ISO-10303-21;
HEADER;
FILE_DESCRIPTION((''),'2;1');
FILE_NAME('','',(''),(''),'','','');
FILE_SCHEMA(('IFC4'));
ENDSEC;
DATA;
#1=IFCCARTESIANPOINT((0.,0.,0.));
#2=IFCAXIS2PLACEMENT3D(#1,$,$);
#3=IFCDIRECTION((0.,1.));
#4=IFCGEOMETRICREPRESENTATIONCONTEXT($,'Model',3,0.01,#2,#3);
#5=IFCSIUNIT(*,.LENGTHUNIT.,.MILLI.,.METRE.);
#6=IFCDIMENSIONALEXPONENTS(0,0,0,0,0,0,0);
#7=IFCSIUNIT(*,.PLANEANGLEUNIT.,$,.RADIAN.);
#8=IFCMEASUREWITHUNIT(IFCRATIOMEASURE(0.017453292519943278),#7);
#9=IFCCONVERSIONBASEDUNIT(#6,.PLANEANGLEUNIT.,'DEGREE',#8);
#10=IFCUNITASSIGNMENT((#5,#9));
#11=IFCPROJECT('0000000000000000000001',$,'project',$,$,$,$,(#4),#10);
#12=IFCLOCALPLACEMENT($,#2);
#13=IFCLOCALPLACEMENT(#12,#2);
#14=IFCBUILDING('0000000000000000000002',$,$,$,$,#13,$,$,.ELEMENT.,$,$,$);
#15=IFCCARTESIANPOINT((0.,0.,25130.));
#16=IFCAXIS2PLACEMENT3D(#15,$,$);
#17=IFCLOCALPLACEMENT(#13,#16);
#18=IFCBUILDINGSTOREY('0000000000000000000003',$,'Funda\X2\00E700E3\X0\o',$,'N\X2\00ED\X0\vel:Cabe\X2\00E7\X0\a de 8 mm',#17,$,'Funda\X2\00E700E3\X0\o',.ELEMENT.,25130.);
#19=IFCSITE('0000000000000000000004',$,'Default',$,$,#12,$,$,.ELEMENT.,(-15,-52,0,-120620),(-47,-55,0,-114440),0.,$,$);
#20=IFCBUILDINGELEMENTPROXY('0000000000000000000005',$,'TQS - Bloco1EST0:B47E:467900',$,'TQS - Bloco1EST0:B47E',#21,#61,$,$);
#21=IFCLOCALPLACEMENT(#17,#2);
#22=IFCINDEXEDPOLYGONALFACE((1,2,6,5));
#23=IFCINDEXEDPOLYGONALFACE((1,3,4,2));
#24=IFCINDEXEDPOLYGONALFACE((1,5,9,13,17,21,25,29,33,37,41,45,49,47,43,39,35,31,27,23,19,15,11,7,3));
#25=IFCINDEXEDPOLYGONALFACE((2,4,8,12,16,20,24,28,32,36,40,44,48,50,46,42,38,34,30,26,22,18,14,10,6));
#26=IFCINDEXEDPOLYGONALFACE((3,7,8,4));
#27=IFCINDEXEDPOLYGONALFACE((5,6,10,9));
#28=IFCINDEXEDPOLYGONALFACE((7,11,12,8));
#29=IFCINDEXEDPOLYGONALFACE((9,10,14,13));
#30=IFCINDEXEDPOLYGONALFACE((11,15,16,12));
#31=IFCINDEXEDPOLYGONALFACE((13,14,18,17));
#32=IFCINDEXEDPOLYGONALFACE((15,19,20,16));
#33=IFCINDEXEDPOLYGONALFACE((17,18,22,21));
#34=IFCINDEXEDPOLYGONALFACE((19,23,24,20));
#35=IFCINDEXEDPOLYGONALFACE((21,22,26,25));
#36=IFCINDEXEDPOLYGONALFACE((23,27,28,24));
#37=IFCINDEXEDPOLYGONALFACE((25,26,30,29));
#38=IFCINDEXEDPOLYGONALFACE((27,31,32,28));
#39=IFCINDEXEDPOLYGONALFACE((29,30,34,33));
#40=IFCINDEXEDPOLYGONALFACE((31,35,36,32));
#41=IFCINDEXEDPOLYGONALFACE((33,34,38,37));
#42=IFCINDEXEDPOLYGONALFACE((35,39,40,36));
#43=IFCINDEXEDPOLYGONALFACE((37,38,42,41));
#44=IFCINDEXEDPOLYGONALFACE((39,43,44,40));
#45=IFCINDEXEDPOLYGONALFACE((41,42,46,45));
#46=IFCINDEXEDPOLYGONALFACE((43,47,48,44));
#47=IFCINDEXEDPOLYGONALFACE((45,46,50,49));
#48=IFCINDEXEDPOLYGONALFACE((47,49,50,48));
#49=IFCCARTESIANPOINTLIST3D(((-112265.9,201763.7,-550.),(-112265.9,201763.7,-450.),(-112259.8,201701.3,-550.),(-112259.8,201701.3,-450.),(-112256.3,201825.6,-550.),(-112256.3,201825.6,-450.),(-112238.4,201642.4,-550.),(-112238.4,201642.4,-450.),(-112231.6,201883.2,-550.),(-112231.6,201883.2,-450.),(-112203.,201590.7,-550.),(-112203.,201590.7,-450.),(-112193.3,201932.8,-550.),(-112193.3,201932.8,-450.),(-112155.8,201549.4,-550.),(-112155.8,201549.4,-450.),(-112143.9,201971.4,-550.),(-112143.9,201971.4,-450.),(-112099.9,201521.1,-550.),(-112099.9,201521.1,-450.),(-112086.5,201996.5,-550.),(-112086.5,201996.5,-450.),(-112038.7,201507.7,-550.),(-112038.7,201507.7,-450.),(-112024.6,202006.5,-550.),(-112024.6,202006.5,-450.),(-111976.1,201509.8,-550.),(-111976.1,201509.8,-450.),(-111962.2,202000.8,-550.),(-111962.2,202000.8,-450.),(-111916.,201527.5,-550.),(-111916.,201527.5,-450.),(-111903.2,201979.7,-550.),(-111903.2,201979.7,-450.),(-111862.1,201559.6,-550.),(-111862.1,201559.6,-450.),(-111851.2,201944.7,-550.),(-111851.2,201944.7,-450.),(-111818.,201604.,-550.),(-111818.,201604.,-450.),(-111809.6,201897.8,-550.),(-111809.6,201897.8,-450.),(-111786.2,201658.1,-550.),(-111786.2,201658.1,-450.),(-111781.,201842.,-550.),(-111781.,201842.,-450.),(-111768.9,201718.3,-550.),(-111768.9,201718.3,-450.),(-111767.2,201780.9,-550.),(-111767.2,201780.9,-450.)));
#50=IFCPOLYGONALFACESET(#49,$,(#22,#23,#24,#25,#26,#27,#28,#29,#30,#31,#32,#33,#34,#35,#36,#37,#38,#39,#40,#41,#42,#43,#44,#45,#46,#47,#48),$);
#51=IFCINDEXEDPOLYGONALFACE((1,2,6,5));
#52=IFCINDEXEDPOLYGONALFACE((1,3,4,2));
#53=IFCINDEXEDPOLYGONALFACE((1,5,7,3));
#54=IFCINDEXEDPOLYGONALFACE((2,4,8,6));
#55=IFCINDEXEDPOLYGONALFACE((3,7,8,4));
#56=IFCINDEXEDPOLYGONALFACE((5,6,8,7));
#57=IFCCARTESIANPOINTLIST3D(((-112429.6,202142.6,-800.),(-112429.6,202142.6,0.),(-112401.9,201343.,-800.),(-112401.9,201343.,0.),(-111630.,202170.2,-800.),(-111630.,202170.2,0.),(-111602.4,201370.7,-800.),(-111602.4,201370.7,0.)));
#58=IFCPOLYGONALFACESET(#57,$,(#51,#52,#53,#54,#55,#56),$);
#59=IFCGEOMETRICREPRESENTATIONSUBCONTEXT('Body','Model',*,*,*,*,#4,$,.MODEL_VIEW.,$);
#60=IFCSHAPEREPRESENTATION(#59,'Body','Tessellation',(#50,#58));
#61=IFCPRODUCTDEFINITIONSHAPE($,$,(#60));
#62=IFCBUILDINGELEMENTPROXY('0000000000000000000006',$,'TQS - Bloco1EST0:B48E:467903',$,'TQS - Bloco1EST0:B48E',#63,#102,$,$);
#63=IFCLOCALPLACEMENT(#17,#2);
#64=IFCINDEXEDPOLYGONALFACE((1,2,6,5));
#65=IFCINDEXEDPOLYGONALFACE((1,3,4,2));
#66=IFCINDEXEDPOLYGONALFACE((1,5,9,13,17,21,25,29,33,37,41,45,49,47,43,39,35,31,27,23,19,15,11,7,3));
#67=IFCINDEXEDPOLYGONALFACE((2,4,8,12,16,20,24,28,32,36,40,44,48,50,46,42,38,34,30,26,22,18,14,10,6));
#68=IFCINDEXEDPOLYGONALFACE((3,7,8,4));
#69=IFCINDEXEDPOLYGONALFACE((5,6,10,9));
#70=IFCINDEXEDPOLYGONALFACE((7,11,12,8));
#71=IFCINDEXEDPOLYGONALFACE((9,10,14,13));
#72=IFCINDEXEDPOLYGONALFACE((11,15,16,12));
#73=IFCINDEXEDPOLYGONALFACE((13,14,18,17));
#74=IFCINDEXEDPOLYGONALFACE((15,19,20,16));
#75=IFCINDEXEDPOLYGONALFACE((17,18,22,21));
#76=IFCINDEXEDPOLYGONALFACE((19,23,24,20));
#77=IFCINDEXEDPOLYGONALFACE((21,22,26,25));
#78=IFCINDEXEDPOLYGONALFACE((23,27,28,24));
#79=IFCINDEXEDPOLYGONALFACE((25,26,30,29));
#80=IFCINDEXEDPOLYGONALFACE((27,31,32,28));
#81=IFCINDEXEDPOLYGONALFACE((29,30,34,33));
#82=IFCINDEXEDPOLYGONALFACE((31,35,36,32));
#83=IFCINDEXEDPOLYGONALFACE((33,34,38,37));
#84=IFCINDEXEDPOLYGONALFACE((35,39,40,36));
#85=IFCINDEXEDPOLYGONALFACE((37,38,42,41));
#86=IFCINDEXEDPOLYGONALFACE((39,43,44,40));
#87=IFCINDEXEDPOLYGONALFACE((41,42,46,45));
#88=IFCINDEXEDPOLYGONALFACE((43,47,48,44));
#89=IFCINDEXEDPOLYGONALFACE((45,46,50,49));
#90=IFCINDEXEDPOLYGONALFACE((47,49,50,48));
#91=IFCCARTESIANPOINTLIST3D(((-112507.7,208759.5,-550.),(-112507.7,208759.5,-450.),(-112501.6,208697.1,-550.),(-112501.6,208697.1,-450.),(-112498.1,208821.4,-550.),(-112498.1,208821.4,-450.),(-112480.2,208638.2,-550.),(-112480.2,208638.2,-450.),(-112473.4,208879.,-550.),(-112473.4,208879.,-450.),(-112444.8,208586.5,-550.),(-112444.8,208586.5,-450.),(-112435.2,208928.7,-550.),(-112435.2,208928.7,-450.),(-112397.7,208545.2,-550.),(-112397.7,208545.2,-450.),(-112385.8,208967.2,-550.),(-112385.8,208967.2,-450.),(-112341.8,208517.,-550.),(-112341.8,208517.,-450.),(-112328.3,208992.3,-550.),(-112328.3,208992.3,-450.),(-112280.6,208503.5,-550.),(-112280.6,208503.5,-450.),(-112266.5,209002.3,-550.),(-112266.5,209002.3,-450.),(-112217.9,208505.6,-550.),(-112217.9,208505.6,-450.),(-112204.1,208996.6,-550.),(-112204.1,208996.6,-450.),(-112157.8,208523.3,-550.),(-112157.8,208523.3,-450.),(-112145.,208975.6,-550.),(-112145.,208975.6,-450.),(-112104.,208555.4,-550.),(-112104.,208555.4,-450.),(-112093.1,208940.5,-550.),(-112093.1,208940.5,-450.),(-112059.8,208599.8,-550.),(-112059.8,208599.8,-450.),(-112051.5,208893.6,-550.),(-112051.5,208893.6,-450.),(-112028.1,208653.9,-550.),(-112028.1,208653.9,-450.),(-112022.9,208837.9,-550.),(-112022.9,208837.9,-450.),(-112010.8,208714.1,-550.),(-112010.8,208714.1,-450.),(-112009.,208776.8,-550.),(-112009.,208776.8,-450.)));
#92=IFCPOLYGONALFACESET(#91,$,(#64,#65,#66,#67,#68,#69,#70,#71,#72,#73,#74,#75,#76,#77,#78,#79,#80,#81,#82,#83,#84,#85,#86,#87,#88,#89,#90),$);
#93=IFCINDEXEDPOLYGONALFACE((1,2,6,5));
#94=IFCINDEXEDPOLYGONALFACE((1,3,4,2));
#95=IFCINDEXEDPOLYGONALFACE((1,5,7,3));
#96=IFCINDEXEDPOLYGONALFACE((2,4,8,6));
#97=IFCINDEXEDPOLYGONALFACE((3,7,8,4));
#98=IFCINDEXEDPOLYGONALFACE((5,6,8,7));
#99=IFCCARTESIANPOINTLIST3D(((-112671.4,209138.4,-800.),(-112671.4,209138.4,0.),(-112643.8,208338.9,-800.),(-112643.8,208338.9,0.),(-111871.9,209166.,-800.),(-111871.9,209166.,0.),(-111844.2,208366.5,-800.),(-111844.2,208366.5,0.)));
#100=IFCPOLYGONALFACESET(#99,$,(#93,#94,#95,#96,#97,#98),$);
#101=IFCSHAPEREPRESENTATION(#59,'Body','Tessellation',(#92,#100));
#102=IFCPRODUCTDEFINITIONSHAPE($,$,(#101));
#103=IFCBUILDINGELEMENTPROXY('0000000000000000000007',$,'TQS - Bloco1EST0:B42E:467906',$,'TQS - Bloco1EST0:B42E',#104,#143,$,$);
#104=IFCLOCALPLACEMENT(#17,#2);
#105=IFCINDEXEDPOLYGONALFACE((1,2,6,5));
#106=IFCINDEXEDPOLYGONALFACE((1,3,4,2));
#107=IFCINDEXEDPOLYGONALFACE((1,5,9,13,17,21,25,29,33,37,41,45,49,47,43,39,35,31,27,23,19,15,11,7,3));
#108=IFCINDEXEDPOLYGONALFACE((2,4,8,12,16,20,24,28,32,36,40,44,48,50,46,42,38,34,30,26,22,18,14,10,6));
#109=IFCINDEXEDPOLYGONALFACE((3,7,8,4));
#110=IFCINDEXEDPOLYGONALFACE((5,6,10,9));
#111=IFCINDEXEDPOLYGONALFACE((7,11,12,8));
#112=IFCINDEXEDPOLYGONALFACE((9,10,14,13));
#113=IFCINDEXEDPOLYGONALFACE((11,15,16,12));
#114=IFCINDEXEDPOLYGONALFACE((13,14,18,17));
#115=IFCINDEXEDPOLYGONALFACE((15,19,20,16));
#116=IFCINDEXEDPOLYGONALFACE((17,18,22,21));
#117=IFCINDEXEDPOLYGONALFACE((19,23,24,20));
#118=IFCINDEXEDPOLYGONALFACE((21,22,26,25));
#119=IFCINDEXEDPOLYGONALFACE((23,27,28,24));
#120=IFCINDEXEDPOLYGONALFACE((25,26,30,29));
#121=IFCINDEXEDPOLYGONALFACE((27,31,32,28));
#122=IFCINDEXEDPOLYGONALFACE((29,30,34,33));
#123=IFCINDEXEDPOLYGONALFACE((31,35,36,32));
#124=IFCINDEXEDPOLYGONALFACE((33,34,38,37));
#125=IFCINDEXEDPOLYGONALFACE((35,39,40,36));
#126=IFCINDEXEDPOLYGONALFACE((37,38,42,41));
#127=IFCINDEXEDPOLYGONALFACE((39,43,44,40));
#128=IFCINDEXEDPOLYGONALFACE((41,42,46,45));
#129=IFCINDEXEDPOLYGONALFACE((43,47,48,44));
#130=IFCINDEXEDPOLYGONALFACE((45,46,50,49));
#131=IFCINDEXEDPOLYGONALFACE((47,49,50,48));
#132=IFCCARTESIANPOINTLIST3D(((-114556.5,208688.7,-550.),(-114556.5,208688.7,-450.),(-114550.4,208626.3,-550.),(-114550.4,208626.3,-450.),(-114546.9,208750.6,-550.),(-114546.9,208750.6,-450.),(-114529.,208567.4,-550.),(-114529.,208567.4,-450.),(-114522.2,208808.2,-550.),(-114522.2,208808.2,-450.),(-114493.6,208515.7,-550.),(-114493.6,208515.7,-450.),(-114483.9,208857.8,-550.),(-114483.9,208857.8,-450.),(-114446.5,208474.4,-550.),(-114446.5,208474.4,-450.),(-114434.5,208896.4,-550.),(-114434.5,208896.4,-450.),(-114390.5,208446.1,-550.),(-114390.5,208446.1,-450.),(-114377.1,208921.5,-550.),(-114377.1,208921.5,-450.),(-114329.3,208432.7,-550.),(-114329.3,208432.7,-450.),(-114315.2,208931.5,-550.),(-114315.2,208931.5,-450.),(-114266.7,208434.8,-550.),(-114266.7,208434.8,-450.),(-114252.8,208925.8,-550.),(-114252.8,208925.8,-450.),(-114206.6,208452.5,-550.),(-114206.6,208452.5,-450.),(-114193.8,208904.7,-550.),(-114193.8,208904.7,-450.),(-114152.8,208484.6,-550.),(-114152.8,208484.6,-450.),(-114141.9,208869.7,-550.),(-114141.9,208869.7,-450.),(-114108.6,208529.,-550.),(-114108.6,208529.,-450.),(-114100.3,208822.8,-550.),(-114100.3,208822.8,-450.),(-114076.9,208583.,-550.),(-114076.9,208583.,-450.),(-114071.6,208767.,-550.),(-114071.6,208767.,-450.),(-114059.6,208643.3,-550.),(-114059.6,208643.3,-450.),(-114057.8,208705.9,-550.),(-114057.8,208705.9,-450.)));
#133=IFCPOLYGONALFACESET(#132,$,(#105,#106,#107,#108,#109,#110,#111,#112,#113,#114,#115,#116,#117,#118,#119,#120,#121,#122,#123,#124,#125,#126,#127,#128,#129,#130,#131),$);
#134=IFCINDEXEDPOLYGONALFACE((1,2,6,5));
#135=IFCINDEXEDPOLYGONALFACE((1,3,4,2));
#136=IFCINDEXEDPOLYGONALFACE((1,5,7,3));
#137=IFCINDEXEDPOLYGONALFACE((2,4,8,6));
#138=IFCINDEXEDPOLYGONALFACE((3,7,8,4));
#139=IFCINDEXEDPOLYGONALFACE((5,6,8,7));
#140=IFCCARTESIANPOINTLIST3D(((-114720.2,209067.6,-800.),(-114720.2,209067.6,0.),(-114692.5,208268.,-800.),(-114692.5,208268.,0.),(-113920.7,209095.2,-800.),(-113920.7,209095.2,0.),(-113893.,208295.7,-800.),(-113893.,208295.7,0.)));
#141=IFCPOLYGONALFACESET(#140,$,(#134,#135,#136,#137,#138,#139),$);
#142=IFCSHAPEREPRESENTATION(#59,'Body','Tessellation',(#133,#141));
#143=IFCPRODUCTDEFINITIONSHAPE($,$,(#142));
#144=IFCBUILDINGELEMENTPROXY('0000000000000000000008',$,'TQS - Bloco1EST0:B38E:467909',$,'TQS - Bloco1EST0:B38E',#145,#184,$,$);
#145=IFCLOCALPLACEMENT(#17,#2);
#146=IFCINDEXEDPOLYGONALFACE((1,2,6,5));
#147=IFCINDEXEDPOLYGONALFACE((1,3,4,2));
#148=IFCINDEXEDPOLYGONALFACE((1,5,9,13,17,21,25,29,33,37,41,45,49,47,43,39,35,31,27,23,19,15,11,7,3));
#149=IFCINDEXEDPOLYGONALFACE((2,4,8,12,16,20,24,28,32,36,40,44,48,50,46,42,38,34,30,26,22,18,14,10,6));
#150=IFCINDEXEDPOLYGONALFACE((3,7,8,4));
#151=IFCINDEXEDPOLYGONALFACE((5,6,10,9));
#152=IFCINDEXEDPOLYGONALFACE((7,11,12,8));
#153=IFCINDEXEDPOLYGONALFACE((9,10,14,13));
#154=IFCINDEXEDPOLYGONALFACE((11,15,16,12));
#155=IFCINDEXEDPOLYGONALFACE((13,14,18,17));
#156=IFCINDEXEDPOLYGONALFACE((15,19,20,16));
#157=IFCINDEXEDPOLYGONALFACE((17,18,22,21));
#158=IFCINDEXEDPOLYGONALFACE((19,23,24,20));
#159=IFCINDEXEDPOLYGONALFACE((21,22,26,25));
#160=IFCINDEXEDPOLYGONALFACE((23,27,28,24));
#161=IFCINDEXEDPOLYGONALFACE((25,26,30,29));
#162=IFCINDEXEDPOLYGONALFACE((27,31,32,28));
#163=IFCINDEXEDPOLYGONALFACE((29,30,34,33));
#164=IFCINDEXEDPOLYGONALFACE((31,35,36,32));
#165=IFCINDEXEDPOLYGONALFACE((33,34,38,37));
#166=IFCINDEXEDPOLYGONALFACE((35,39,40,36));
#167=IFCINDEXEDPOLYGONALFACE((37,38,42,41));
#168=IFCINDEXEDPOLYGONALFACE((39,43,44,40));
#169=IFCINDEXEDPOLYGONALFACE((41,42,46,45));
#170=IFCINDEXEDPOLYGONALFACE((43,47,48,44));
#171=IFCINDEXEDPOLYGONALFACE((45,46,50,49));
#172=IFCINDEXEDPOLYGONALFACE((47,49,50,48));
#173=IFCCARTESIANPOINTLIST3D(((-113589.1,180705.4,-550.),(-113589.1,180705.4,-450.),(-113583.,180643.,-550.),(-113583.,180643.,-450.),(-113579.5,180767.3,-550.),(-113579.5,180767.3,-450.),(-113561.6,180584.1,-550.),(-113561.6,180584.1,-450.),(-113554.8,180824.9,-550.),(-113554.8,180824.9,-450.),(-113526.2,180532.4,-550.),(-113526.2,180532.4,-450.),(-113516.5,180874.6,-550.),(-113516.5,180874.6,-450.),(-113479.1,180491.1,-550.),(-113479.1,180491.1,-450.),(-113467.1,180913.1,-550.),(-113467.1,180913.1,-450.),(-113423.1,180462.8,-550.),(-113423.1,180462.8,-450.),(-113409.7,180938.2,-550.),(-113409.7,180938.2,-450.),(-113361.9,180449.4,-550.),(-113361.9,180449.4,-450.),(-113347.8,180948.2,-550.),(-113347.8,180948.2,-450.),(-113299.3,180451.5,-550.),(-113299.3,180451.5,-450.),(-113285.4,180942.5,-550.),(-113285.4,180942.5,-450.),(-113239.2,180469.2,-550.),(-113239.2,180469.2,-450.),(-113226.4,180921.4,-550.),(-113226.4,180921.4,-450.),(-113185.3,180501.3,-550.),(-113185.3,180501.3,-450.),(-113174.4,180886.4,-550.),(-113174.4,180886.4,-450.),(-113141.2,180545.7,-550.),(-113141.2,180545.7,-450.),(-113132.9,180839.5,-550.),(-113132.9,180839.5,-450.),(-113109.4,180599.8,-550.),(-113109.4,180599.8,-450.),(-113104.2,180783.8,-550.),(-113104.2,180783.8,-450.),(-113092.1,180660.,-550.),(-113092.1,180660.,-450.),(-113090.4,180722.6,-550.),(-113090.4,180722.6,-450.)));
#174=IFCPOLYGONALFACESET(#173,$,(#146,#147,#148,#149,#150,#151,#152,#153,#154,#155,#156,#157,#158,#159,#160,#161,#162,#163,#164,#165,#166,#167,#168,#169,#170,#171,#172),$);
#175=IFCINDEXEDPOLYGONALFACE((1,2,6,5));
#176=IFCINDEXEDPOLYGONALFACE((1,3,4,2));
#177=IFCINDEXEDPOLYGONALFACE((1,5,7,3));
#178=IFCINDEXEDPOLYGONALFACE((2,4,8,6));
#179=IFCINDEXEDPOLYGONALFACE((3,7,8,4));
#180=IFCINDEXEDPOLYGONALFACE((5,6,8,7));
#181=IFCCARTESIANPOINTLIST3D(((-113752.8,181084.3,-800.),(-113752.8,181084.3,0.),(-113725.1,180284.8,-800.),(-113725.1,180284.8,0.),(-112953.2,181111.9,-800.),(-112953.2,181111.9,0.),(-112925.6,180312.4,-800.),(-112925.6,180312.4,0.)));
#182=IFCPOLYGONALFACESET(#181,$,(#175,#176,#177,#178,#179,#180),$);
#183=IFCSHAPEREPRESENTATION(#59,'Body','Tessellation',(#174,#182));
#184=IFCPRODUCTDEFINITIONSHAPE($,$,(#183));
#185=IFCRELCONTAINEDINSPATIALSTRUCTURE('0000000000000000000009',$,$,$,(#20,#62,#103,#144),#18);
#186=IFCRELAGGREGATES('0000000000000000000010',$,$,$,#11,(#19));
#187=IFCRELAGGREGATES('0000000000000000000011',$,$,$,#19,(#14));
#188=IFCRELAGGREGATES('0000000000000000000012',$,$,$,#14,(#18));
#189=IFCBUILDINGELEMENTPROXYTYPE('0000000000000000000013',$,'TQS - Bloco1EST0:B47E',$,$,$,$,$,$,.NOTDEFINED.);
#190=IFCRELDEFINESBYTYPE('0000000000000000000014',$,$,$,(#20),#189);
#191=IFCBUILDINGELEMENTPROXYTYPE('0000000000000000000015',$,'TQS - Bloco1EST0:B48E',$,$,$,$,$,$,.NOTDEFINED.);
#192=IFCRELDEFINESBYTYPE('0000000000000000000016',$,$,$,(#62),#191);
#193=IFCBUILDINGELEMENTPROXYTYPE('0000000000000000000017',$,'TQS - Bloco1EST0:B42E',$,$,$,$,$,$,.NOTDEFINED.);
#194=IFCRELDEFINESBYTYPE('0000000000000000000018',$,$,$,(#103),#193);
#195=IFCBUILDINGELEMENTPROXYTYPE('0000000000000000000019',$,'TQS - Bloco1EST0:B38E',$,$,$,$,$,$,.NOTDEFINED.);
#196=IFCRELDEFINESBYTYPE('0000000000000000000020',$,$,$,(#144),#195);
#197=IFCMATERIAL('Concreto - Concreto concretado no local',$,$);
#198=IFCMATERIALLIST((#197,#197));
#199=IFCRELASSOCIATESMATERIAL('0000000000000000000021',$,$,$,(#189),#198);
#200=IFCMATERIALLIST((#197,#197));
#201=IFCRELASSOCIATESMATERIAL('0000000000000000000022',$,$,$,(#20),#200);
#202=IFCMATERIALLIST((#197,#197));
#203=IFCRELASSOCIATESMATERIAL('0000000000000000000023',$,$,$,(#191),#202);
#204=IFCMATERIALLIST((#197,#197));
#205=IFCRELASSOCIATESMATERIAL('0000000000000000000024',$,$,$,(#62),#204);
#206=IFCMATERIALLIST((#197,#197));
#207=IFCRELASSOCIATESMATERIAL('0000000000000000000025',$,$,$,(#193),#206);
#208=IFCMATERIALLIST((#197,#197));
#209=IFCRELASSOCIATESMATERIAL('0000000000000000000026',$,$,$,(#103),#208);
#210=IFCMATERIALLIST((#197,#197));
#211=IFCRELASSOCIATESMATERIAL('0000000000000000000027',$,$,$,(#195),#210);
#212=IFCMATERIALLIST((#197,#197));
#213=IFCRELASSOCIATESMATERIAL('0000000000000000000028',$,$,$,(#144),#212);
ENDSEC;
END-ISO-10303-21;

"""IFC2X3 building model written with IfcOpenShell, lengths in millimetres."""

from ifc_helpers import new_model, entity, si_unit, converted_unit, direction, frame, frame_2d, origin, origin_2d_with_axis, place, context, subcontext, project, spatial, rectangle, circle, extrude, source, transform, mapped, material, material_list, type_object, type_shapes, element, save


model = new_model("IFC2X3")

# Units and contexts
model_context = context("Model", 3, precision=0.01, world=origin(), true_north=direction((0.0, 1.0)))
body_context = subcontext(model_context, "Body", "Model", "MODEL_VIEW")
ifc_project = project(units=[si_unit("LENGTHUNIT", "METRE", prefix="MILLI"), converted_unit("PLANEANGLEUNIT", "DEGREE", entity("IfcRatioMeasure", 0.017453292519943278), si_unit("PLANEANGLEUNIT", "RADIAN"), dimensions=[0, 0, 0, 0, 0, 0, 0])], contexts=[model_context])

# Site, building, storey
site_placement = place(None, origin())
site = spatial("IfcSite", under=ifc_project, at=site_placement, Name="Default", CompositionType="ELEMENT", RefLatitude=(-15, -52, 0, -120620), RefLongitude=(-47, -55, 0, -114440), RefElevation=0.0)
building_placement = place(site_placement, origin())
building = spatial("IfcBuilding", under=site, at=building_placement, CompositionType="ELEMENT")
storey_placement = place(building_placement, frame((0.0, 0.0, 25130.0)))
storey = spatial("IfcBuildingStorey", under=building, at=storey_placement, Name="Fundação", ObjectType="Nível:Cabeça de 8 mm", LongName="Fundação", CompositionType="ELEMENT", Elevation=25130.0)

# Building element proxies
ifc_material_1 = material(Name="Concreto - Concreto concretado no local")
ifc_material_list_1 = material_list([ifc_material_1, ifc_material_1])
ifc_material_list_2 = material_list([ifc_material_1, ifc_material_1])
building_element_proxy_type_1 = type_object("IfcBuildingElementProxyType", Name="TQS - Bloco1EST0:B47E", PredefinedType="NOTDEFINED", material=ifc_material_list_2)
shared_shape_1 = source(origin(), body_context, "Body", "SweptSolid", [
    extrude(circle(Radius=250.0, at=frame_2d((0.0, 0.0), x_axis=(1.0, 0.0))), frame((0.0, 0.0, -550.0)), (0.0, 0.0, 1.0), 100.0),
    extrude(rectangle(XDim=800.0, YDim=800.0, at=origin_2d_with_axis()), frame((0.0, 0.0, -800.0), z_axis=(0.0, 0.0, 1.0), x_axis=(-1.0, 0.0, 0.0)), (0.0, 0.0, 1.0), 800.0),
])
type_shapes(building_element_proxy_type_1, [shared_shape_1])
proxy_1_placement = place(storey_placement, frame((-112016.0, 201756.6, 0.0), z_axis=(0.0, 0.0, 1.0), x_axis=(-0.034551, 0.999403, 0.0)))
element("IfcBuildingElementProxy", 1, at=proxy_1_placement, inside=storey, type_object=building_element_proxy_type_1, material=ifc_material_list_1, Name="TQS - Bloco1EST0:B47E:467900", ObjectType="TQS - Bloco1EST0:B47E", context=body_context, shape_type="MappedRepresentation", body=[
    mapped(shared_shape_1, transform((0.0, 0.0, 0.0), scale=1.0)),
])
ifc_material_list_3 = material_list([ifc_material_1, ifc_material_1])
ifc_material_list_4 = material_list([ifc_material_1, ifc_material_1])
building_element_proxy_type_2 = type_object("IfcBuildingElementProxyType", Name="TQS - Bloco1EST0:B48E", PredefinedType="NOTDEFINED", material=ifc_material_list_4)
shared_shape_2 = source(origin(), body_context, "Body", "SweptSolid", [
    extrude(circle(Radius=250.0, at=frame_2d((0.0, 0.0), x_axis=(1.0, 0.0))), frame((0.0, 0.0, -550.0)), (0.0, 0.0, 1.0), 100.0),
    extrude(rectangle(XDim=800.0, YDim=800.0, at=origin_2d_with_axis()), frame((0.0, 0.0, -800.0), z_axis=(0.0, 0.0, 1.0), x_axis=(-1.0, 0.0, 0.0)), (0.0, 0.0, 1.0), 800.0),
])
type_shapes(building_element_proxy_type_2, [shared_shape_2])
proxy_2_placement = place(storey_placement, frame((-112257.8, 208752.4, 0.0), z_axis=(0.0, 0.0, 1.0), x_axis=(-0.034551, 0.999403, 0.0)))
element("IfcBuildingElementProxy", 2, at=proxy_2_placement, inside=storey, type_object=building_element_proxy_type_2, material=ifc_material_list_3, Name="TQS - Bloco1EST0:B48E:467903", ObjectType="TQS - Bloco1EST0:B48E", context=body_context, shape_type="MappedRepresentation", body=[
    mapped(shared_shape_2, transform((0.0, 0.0, 0.0), scale=1.0)),
])
ifc_material_list_5 = material_list([ifc_material_1, ifc_material_1])
ifc_material_list_6 = material_list([ifc_material_1, ifc_material_1])
building_element_proxy_type_3 = type_object("IfcBuildingElementProxyType", Name="TQS - Bloco1EST0:B42E", PredefinedType="NOTDEFINED", material=ifc_material_list_6)
shared_shape_3 = source(origin(), body_context, "Body", "SweptSolid", [
    extrude(circle(Radius=250.0, at=frame_2d((0.0, 0.0), x_axis=(1.0, 0.0))), frame((0.0, 0.0, -550.0)), (0.0, 0.0, 1.0), 100.0),
    extrude(rectangle(XDim=800.0, YDim=800.0, at=origin_2d_with_axis()), frame((0.0, 0.0, -800.0), z_axis=(0.0, 0.0, 1.0), x_axis=(-1.0, 0.0, 0.0)), (0.0, 0.0, 1.0), 800.0),
])
type_shapes(building_element_proxy_type_3, [shared_shape_3])
proxy_3_placement = place(storey_placement, frame((-114306.6, 208681.6, 0.0), z_axis=(0.0, 0.0, 1.0), x_axis=(-0.034551, 0.999403, 0.0)))
element("IfcBuildingElementProxy", 3, at=proxy_3_placement, inside=storey, type_object=building_element_proxy_type_3, material=ifc_material_list_5, Name="TQS - Bloco1EST0:B42E:467906", ObjectType="TQS - Bloco1EST0:B42E", context=body_context, shape_type="MappedRepresentation", body=[
    mapped(shared_shape_3, transform((0.0, 0.0, 0.0), scale=1.0)),
])
ifc_material_list_7 = material_list([ifc_material_1, ifc_material_1])
ifc_material_list_8 = material_list([ifc_material_1, ifc_material_1])
building_element_proxy_type_4 = type_object("IfcBuildingElementProxyType", Name="TQS - Bloco1EST0:B38E", PredefinedType="NOTDEFINED", material=ifc_material_list_8)
shared_shape_4 = source(origin(), body_context, "Body", "SweptSolid", [
    extrude(circle(Radius=250.0, at=frame_2d((0.0, 0.0), x_axis=(1.0, 0.0))), frame((0.0, 0.0, -550.0)), (0.0, 0.0, 1.0), 100.0),
    extrude(rectangle(XDim=800.0, YDim=800.0, at=origin_2d_with_axis()), frame((0.0, 0.0, -800.0), z_axis=(0.0, 0.0, 1.0), x_axis=(-1.0, 0.0, 0.0)), (0.0, 0.0, 1.0), 800.0),
])
type_shapes(building_element_proxy_type_4, [shared_shape_4])
proxy_4_placement = place(storey_placement, frame((-113339.2, 180698.3, 0.0), z_axis=(0.0, 0.0, 1.0), x_axis=(-0.034551, 0.999403, 0.0)))
element("IfcBuildingElementProxy", 4, at=proxy_4_placement, inside=storey, type_object=building_element_proxy_type_4, material=ifc_material_list_7, Name="TQS - Bloco1EST0:B38E:467909", ObjectType="TQS - Bloco1EST0:B38E", context=body_context, shape_type="MappedRepresentation", body=[
    mapped(shared_shape_4, transform((0.0, 0.0, 0.0), scale=1.0)),
])

save(model, "model.ifc")
